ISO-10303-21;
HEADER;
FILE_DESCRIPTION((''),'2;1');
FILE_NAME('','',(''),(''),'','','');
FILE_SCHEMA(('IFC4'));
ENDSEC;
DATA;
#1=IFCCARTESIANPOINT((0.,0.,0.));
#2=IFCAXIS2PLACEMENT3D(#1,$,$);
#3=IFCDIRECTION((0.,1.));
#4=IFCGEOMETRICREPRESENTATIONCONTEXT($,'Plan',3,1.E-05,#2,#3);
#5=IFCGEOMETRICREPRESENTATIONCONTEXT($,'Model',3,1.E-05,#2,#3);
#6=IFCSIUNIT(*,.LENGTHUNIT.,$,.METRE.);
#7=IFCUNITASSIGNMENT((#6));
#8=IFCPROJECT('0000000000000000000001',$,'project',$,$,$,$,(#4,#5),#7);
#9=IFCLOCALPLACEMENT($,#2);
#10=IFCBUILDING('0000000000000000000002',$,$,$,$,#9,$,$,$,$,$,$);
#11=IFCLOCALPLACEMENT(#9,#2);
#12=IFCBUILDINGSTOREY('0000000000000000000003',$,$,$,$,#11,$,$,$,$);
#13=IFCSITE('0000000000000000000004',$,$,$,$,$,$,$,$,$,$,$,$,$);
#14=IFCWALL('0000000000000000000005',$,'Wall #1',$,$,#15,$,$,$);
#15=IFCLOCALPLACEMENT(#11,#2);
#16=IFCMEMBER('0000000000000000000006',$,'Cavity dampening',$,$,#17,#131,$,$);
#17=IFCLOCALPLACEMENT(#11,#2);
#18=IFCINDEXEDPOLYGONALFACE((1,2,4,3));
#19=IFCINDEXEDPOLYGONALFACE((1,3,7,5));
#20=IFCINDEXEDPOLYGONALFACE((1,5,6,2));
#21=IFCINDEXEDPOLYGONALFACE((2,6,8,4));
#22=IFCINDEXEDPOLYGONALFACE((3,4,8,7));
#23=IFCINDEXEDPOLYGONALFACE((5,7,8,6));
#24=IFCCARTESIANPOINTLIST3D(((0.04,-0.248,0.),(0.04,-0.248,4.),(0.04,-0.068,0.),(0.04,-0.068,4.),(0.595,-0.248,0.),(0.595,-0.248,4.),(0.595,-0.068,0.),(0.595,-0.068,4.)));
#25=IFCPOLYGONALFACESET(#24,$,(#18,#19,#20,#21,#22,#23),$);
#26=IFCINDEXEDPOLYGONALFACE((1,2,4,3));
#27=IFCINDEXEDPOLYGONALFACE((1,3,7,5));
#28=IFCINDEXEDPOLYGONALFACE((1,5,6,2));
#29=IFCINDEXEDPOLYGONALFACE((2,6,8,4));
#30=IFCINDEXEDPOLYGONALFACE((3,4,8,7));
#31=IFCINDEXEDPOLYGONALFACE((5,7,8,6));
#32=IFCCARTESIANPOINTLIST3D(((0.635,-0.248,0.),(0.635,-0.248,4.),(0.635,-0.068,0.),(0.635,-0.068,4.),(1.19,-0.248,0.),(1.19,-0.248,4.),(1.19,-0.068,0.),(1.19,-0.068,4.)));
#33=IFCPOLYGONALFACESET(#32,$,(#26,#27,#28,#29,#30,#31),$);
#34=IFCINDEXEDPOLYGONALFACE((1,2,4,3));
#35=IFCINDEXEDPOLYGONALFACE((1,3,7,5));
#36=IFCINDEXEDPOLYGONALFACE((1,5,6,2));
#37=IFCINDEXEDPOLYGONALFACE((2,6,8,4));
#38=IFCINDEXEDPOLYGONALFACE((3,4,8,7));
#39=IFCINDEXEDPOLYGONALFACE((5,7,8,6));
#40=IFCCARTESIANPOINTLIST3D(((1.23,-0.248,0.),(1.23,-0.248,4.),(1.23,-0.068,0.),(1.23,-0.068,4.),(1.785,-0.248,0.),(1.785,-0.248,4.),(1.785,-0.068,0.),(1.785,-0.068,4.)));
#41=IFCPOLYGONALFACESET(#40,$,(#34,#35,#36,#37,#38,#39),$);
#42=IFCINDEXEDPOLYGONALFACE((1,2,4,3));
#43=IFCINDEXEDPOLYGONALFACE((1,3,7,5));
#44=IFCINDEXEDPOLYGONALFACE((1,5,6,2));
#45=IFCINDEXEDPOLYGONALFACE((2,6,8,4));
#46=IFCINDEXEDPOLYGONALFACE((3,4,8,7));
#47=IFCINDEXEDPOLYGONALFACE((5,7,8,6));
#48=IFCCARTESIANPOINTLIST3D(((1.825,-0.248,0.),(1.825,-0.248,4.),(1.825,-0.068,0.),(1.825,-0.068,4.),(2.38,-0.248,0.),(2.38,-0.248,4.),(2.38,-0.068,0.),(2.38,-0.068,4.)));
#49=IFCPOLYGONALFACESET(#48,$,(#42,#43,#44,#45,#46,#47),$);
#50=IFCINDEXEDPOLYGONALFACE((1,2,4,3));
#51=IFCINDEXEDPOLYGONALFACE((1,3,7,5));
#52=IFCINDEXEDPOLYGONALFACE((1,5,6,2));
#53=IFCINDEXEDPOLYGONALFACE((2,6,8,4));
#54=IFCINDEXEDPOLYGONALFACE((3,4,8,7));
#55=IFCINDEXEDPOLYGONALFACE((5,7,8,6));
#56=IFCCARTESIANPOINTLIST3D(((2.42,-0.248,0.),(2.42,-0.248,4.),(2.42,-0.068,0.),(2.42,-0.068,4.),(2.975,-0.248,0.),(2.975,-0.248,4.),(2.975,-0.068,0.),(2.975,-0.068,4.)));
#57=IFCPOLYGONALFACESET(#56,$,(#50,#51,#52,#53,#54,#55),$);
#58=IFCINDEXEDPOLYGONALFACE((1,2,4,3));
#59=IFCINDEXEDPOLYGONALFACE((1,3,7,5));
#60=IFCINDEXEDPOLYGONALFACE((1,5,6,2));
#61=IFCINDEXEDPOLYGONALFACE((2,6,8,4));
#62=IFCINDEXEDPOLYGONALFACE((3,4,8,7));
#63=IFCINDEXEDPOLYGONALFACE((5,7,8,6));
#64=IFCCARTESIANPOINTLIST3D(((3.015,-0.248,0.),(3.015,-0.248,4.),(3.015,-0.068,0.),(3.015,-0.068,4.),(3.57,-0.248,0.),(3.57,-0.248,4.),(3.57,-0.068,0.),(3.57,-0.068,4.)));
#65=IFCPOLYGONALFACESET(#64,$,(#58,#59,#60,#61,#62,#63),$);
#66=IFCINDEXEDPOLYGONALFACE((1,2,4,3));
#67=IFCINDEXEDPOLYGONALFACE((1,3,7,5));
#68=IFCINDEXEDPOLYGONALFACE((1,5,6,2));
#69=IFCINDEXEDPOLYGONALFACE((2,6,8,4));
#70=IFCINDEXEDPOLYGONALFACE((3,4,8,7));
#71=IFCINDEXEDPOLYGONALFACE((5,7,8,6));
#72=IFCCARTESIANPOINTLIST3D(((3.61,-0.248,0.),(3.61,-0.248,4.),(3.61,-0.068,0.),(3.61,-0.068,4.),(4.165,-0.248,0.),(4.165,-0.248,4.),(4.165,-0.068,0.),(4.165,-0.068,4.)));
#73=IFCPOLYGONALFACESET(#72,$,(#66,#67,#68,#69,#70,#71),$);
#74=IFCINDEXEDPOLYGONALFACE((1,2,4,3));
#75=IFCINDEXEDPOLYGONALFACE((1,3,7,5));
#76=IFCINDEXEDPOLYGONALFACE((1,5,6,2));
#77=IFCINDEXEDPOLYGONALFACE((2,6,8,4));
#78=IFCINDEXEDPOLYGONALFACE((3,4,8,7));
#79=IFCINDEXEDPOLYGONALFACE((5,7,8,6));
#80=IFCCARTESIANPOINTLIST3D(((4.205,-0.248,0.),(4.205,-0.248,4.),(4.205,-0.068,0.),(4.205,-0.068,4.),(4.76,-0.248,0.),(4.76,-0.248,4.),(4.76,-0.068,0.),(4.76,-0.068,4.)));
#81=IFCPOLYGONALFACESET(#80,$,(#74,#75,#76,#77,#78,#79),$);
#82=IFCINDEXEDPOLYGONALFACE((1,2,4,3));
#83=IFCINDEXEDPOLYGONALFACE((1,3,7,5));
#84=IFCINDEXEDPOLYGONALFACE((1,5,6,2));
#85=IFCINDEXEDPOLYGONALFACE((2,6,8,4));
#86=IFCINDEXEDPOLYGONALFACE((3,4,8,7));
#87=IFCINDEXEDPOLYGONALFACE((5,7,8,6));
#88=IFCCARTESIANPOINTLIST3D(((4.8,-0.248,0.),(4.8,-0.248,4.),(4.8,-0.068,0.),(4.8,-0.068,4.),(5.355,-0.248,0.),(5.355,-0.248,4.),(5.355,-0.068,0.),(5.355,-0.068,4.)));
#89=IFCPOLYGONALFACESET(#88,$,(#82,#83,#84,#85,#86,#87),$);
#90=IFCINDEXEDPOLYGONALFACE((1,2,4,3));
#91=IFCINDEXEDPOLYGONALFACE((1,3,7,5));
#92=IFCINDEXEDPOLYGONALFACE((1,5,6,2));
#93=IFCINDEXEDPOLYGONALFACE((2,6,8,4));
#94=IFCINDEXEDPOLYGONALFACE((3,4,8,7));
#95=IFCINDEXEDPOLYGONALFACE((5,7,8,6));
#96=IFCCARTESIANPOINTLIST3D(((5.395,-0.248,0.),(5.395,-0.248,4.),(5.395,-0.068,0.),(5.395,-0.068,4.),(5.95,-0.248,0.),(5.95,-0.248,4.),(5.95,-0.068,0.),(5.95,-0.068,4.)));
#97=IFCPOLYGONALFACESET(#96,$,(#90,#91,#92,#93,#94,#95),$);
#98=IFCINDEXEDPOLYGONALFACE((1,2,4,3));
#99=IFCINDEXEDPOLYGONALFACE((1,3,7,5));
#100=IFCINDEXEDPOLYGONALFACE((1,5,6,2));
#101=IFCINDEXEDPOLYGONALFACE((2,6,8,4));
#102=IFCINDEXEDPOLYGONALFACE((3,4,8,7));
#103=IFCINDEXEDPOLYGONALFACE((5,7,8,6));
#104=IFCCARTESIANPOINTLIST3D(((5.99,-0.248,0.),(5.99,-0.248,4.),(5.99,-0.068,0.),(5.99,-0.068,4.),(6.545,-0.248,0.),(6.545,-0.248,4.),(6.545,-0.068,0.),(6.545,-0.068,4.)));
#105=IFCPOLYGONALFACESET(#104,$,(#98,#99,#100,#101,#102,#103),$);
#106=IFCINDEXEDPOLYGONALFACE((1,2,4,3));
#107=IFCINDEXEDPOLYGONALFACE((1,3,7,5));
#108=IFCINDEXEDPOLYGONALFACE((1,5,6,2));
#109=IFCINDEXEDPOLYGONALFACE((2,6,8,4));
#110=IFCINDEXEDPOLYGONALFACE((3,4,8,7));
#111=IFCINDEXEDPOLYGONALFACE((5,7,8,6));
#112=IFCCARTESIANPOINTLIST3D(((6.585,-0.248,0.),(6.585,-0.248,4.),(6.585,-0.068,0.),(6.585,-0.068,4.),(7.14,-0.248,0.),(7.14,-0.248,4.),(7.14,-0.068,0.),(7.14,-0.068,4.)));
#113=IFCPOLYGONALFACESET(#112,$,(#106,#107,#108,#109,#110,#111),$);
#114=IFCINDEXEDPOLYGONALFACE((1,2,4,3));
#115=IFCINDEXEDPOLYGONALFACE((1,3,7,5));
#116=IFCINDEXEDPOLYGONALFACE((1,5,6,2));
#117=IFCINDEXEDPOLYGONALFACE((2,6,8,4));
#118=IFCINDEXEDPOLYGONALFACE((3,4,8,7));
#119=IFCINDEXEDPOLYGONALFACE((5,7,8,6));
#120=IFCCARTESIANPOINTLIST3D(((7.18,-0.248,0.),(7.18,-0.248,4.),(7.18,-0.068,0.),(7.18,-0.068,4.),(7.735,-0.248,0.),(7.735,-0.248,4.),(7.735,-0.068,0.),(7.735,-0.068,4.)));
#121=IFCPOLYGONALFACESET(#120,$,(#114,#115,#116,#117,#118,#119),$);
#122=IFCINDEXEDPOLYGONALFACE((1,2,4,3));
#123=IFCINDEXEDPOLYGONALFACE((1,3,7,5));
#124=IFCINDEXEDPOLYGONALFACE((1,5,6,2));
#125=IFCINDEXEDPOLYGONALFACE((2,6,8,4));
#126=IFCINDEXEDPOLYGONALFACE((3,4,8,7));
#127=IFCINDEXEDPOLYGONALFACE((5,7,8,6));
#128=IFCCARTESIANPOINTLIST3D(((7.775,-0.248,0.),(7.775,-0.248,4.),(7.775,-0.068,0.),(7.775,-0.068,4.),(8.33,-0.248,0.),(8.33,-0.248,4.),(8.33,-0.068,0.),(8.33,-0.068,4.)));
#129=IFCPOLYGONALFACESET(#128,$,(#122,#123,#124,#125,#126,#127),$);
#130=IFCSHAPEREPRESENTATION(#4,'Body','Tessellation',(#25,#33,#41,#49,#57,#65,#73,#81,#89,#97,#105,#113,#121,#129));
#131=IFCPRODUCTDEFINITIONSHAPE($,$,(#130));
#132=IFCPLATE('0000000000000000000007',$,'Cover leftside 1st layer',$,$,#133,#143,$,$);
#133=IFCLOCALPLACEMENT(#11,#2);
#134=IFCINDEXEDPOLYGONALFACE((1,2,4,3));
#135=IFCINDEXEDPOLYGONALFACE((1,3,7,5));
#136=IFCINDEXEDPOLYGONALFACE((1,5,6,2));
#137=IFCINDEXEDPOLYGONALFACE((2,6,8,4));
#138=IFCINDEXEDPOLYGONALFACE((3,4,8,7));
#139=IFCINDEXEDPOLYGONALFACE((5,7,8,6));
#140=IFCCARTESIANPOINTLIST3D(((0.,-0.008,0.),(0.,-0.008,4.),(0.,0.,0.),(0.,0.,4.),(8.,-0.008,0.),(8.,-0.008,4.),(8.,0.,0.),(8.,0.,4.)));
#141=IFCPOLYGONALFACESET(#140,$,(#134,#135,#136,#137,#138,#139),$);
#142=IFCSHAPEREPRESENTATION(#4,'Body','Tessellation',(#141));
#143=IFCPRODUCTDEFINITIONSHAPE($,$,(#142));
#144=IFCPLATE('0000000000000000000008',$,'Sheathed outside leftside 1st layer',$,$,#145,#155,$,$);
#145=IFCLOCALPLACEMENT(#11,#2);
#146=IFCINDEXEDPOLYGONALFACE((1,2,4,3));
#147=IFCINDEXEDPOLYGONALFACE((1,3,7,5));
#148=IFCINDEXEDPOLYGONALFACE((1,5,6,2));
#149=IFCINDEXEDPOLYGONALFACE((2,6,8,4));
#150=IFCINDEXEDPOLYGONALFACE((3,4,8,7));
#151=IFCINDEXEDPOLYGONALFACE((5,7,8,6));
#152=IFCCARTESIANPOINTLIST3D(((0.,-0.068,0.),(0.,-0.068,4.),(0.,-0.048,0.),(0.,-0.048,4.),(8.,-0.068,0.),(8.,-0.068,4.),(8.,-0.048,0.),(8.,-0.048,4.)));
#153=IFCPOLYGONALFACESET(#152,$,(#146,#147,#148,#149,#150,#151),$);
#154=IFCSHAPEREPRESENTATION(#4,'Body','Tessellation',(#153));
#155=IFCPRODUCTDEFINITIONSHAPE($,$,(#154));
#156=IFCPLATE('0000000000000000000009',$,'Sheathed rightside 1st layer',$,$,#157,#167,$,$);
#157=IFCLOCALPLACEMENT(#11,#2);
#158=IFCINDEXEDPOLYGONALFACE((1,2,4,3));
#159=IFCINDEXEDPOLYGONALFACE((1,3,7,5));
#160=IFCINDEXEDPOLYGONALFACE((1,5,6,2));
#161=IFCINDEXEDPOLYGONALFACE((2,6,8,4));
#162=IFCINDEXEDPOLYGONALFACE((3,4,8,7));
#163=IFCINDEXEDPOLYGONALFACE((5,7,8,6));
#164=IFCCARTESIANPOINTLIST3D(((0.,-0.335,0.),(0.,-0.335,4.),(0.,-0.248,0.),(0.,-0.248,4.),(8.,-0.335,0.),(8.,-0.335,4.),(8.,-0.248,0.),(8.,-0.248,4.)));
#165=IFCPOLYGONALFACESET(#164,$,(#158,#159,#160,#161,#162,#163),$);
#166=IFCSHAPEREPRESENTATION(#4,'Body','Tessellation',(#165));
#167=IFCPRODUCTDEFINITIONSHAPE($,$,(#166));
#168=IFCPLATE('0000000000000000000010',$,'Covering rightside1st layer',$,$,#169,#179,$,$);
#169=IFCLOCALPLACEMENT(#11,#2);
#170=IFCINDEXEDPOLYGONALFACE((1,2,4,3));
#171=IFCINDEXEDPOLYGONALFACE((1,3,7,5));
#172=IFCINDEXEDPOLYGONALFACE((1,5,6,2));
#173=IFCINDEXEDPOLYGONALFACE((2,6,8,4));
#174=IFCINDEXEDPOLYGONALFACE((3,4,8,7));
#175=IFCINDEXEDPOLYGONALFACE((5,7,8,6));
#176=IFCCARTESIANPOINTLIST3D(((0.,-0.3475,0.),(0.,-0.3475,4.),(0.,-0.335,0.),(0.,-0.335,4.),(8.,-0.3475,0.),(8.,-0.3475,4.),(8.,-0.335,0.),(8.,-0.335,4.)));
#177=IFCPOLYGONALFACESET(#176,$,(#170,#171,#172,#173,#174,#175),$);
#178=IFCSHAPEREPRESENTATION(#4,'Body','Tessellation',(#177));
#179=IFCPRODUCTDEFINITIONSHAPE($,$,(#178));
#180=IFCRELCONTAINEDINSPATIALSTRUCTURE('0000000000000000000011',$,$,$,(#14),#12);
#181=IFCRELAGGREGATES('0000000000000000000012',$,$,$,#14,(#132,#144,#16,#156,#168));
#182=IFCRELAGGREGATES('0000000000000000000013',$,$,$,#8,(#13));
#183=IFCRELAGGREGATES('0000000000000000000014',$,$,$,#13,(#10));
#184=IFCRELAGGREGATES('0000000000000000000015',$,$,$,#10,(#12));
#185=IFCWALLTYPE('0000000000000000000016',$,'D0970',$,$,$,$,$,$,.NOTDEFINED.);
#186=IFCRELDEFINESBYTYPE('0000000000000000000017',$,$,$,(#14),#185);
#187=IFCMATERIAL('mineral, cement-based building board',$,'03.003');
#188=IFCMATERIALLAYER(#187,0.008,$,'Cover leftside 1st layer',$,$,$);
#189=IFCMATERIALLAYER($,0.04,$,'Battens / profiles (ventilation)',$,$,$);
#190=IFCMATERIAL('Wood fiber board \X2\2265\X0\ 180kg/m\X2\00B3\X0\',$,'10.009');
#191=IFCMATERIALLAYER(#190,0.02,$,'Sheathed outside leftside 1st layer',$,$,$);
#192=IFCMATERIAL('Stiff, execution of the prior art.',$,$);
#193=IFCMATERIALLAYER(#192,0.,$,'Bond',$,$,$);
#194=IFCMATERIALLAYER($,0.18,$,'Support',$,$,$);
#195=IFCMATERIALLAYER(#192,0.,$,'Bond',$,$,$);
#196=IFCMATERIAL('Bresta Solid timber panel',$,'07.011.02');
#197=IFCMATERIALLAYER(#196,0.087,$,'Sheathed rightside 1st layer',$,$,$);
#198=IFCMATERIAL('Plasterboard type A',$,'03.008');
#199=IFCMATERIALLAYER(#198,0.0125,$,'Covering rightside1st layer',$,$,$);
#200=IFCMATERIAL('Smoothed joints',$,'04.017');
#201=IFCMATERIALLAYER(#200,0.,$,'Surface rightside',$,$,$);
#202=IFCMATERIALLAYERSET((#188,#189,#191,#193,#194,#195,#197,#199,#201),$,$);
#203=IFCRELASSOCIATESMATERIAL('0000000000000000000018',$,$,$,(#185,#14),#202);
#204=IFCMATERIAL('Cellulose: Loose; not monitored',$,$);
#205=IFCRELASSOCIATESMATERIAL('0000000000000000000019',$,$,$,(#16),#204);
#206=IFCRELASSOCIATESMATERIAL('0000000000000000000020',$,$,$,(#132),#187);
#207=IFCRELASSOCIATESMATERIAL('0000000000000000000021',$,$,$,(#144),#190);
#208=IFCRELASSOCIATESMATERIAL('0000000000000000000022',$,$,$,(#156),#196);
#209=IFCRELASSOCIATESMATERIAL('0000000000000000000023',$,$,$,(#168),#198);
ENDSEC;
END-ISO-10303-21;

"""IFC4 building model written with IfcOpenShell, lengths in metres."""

from ifc_helpers import new_model, si_unit, direction, frame, frame_2d, origin, origin_with_axes, place, context, project, spatial, rectangle, extrude, material, layer, layer_set, type_object, element, aggregate, save


model = new_model("IFC4")

# Units and contexts
plan_context = context("Plan", 3, precision=1e-05, world=origin(), true_north=direction((0.0, 1.0)))
model_context = context("Model", 3, precision=1e-05, world=origin(), true_north=direction((0.0, 1.0)))
ifc_project = project(units=[si_unit("LENGTHUNIT", "METRE")], contexts=[plan_context, model_context])

# Site, building, storey
site = spatial("IfcSite", under=ifc_project)
building_placement = place(None, origin())
building = spatial("IfcBuilding", under=site, at=building_placement)
storey_placement = place(building_placement, origin())
storey = spatial("IfcBuildingStorey", under=building, at=storey_placement)

# Wall, member, plates
ifc_material_1 = material(Name="mineral, cement-based building board", Category="03.003")
ifc_layer_1 = layer(ifc_material_1, 0.008, Name="Cover leftside 1st layer")
ifc_layer_2 = layer(None, 0.04, Name="Battens / profiles (ventilation)")
ifc_material_2 = material(Name="Wood fiber board ≥ 180kg/m³", Category="10.009")
ifc_layer_3 = layer(ifc_material_2, 0.02, Name="Sheathed outside leftside 1st layer")
ifc_material_3 = material(Name="Stiff, execution of the prior art.")
ifc_layer_4 = layer(ifc_material_3, 0.0, Name="Bond")
ifc_layer_5 = layer(None, 0.18, Name="Support")
ifc_layer_6 = layer(ifc_material_3, 0.0, Name="Bond")
ifc_material_4 = material(Name="Bresta Solid timber panel", Category="07.011.02")
ifc_layer_7 = layer(ifc_material_4, 0.087, Name="Sheathed rightside 1st layer")
ifc_material_5 = material(Name="Plasterboard type A", Category="03.008")
ifc_layer_8 = layer(ifc_material_5, 0.0125, Name="Covering rightside1st layer")
ifc_material_6 = material(Name="Smoothed joints", Category="04.017")
ifc_layer_9 = layer(ifc_material_6, 0.0, Name="Surface rightside")
ifc_layer_set = layer_set([ifc_layer_1, ifc_layer_2, ifc_layer_3, ifc_layer_4, ifc_layer_5, ifc_layer_6, ifc_layer_7, ifc_layer_8, ifc_layer_9])
wall_type = type_object("IfcWallType", Name="D0970", PredefinedType="NOTDEFINED", material=ifc_layer_set)
wall_placement = place(None, frame((0.0, 0.0, 0.0), z_axis=(0.0, -1.0, 0.0), x_axis=(1.0, 0.0, 0.0)))
wall = element("IfcWall", 1, at=wall_placement, inside=storey, type_object=wall_type, material=ifc_layer_set, Name="Wall #1")
ifc_material_7 = material(Name="Cellulose: Loose; not monitored")
member_1_placement = place(wall_placement, origin())
member_1 = element("IfcMember", 2, at=member_1_placement, material=ifc_material_7, Name="Cavity dampening", context=plan_context, shape_type="SweptSolid", body=[
    extrude(rectangle(XDim=0.555, YDim=0.18, at=frame_2d((0.2775, 0.09), x_axis=(1.0, 0.0))), frame((0.04, 4.0, 0.068), z_axis=(0.0, -1.0, 0.0), x_axis=(1.0, 0.0, 0.0)), (0.0, 0.0, 1.0), 4.0),
    extrude(rectangle(XDim=0.555, YDim=0.18, at=frame_2d((0.2775, 0.09), x_axis=(1.0, 0.0))), frame((0.635, 4.0, 0.068), z_axis=(0.0, -1.0, 0.0), x_axis=(1.0, 0.0, 0.0)), (0.0, 0.0, 1.0), 4.0),
    extrude(rectangle(XDim=0.555, YDim=0.18, at=frame_2d((0.2775, 0.09), x_axis=(1.0, 0.0))), frame((1.23, 4.0, 0.068), z_axis=(0.0, -1.0, 0.0), x_axis=(1.0, 0.0, 0.0)), (0.0, 0.0, 1.0), 4.0),
    extrude(rectangle(XDim=0.555, YDim=0.18, at=frame_2d((0.2775, 0.09), x_axis=(1.0, 0.0))), frame((1.825, 4.0, 0.068), z_axis=(0.0, -1.0, 0.0), x_axis=(1.0, 0.0, 0.0)), (0.0, 0.0, 1.0), 4.0),
    extrude(rectangle(XDim=0.555, YDim=0.18, at=frame_2d((0.2775, 0.09), x_axis=(1.0, 0.0))), frame((2.42, 4.0, 0.068), z_axis=(0.0, -1.0, 0.0), x_axis=(1.0, 0.0, 0.0)), (0.0, 0.0, 1.0), 4.0),
    extrude(rectangle(XDim=0.555, YDim=0.18, at=frame_2d((0.2775, 0.09), x_axis=(1.0, 0.0))), frame((3.015, 4.0, 0.068), z_axis=(0.0, -1.0, 0.0), x_axis=(1.0, 0.0, 0.0)), (0.0, 0.0, 1.0), 4.0),
    extrude(rectangle(XDim=0.555, YDim=0.18, at=frame_2d((0.2775, 0.09), x_axis=(1.0, 0.0))), frame((3.61, 4.0, 0.068), z_axis=(0.0, -1.0, 0.0), x_axis=(1.0, 0.0, 0.0)), (0.0, 0.0, 1.0), 4.0),
    extrude(rectangle(XDim=0.555, YDim=0.18, at=frame_2d((0.2775, 0.09), x_axis=(1.0, 0.0))), frame((4.205, 4.0, 0.068), z_axis=(0.0, -1.0, 0.0), x_axis=(1.0, 0.0, 0.0)), (0.0, 0.0, 1.0), 4.0),
    extrude(rectangle(XDim=0.555, YDim=0.18, at=frame_2d((0.2775, 0.09), x_axis=(1.0, 0.0))), frame((4.8, 4.0, 0.068), z_axis=(0.0, -1.0, 0.0), x_axis=(1.0, 0.0, 0.0)), (0.0, 0.0, 1.0), 4.0),
    extrude(rectangle(XDim=0.555, YDim=0.18, at=frame_2d((0.2775, 0.09), x_axis=(1.0, 0.0))), frame((5.395, 4.0, 0.068), z_axis=(0.0, -1.0, 0.0), x_axis=(1.0, 0.0, 0.0)), (0.0, 0.0, 1.0), 4.0),
    extrude(rectangle(XDim=0.555, YDim=0.18, at=frame_2d((0.2775, 0.09), x_axis=(1.0, 0.0))), frame((5.99, 4.0, 0.068), z_axis=(0.0, -1.0, 0.0), x_axis=(1.0, 0.0, 0.0)), (0.0, 0.0, 1.0), 4.0),
    extrude(rectangle(XDim=0.555, YDim=0.18, at=frame_2d((0.2775, 0.09), x_axis=(1.0, 0.0))), frame((6.585, 4.0, 0.068), z_axis=(0.0, -1.0, 0.0), x_axis=(1.0, 0.0, 0.0)), (0.0, 0.0, 1.0), 4.0),
    extrude(rectangle(XDim=0.555, YDim=0.18, at=frame_2d((0.2775, 0.09), x_axis=(1.0, 0.0))), frame((7.18, 4.0, 0.068), z_axis=(0.0, -1.0, 0.0), x_axis=(1.0, 0.0, 0.0)), (0.0, 0.0, 1.0), 4.0),
    extrude(rectangle(XDim=0.555, YDim=0.18, at=frame_2d((0.2775, 0.09), x_axis=(1.0, 0.0))), frame((7.775, 4.0, 0.068), z_axis=(0.0, -1.0, 0.0), x_axis=(1.0, 0.0, 0.0)), (0.0, 0.0, 1.0), 4.0),
])
plate_1_placement = place(wall_placement, origin())
plate_1 = element("IfcPlate", 3, at=plate_1_placement, material=ifc_material_1, Name="Cover leftside 1st layer", context=plan_context, shape_type="SweptSolid", body=[
    extrude(rectangle(XDim=8.0, YDim=4.0, at=frame_2d((4.0, 2.0), x_axis=(1.0, 0.0))), origin_with_axes(), (0.0, 0.0, 1.0), 0.008),
])
plate_2_placement = place(wall_placement, origin())
plate_2 = element("IfcPlate", 4, at=plate_2_placement, material=ifc_material_2, Name="Sheathed outside leftside 1st layer", context=plan_context, shape_type="SweptSolid", body=[
    extrude(rectangle(XDim=8.0, YDim=4.0, at=frame_2d((4.0, 2.0), x_axis=(1.0, 0.0))), frame((0.0, 0.0, 0.048), z_axis=(0.0, 0.0, 1.0), x_axis=(1.0, 0.0, 0.0)), (0.0, 0.0, 1.0), 0.02),
])
plate_3_placement = place(wall_placement, origin())
plate_3 = element("IfcPlate", 5, at=plate_3_placement, material=ifc_material_4, Name="Sheathed rightside 1st layer", context=plan_context, shape_type="SweptSolid", body=[
    extrude(rectangle(XDim=8.0, YDim=4.0, at=frame_2d((4.0, 2.0), x_axis=(1.0, 0.0))), frame((0.0, 0.0, 0.248), z_axis=(0.0, 0.0, 1.0), x_axis=(1.0, 0.0, 0.0)), (0.0, 0.0, 1.0), 0.087),
])
plate_4_placement = place(wall_placement, origin())
plate_4 = element("IfcPlate", 6, at=plate_4_placement, material=ifc_material_5, Name="Covering rightside1st layer", context=plan_context, shape_type="SweptSolid", body=[
    extrude(rectangle(XDim=8.0, YDim=4.0, at=frame_2d((4.0, 2.0), x_axis=(1.0, 0.0))), frame((0.0, 0.0, 0.335), z_axis=(0.0, 0.0, 1.0), x_axis=(1.0, 0.0, 0.0)), (0.0, 0.0, 1.0), 0.0125),
])
aggregate(wall, [plate_1, plate_2, member_1, plate_3, plate_4])

save(model, "model.ifc")
